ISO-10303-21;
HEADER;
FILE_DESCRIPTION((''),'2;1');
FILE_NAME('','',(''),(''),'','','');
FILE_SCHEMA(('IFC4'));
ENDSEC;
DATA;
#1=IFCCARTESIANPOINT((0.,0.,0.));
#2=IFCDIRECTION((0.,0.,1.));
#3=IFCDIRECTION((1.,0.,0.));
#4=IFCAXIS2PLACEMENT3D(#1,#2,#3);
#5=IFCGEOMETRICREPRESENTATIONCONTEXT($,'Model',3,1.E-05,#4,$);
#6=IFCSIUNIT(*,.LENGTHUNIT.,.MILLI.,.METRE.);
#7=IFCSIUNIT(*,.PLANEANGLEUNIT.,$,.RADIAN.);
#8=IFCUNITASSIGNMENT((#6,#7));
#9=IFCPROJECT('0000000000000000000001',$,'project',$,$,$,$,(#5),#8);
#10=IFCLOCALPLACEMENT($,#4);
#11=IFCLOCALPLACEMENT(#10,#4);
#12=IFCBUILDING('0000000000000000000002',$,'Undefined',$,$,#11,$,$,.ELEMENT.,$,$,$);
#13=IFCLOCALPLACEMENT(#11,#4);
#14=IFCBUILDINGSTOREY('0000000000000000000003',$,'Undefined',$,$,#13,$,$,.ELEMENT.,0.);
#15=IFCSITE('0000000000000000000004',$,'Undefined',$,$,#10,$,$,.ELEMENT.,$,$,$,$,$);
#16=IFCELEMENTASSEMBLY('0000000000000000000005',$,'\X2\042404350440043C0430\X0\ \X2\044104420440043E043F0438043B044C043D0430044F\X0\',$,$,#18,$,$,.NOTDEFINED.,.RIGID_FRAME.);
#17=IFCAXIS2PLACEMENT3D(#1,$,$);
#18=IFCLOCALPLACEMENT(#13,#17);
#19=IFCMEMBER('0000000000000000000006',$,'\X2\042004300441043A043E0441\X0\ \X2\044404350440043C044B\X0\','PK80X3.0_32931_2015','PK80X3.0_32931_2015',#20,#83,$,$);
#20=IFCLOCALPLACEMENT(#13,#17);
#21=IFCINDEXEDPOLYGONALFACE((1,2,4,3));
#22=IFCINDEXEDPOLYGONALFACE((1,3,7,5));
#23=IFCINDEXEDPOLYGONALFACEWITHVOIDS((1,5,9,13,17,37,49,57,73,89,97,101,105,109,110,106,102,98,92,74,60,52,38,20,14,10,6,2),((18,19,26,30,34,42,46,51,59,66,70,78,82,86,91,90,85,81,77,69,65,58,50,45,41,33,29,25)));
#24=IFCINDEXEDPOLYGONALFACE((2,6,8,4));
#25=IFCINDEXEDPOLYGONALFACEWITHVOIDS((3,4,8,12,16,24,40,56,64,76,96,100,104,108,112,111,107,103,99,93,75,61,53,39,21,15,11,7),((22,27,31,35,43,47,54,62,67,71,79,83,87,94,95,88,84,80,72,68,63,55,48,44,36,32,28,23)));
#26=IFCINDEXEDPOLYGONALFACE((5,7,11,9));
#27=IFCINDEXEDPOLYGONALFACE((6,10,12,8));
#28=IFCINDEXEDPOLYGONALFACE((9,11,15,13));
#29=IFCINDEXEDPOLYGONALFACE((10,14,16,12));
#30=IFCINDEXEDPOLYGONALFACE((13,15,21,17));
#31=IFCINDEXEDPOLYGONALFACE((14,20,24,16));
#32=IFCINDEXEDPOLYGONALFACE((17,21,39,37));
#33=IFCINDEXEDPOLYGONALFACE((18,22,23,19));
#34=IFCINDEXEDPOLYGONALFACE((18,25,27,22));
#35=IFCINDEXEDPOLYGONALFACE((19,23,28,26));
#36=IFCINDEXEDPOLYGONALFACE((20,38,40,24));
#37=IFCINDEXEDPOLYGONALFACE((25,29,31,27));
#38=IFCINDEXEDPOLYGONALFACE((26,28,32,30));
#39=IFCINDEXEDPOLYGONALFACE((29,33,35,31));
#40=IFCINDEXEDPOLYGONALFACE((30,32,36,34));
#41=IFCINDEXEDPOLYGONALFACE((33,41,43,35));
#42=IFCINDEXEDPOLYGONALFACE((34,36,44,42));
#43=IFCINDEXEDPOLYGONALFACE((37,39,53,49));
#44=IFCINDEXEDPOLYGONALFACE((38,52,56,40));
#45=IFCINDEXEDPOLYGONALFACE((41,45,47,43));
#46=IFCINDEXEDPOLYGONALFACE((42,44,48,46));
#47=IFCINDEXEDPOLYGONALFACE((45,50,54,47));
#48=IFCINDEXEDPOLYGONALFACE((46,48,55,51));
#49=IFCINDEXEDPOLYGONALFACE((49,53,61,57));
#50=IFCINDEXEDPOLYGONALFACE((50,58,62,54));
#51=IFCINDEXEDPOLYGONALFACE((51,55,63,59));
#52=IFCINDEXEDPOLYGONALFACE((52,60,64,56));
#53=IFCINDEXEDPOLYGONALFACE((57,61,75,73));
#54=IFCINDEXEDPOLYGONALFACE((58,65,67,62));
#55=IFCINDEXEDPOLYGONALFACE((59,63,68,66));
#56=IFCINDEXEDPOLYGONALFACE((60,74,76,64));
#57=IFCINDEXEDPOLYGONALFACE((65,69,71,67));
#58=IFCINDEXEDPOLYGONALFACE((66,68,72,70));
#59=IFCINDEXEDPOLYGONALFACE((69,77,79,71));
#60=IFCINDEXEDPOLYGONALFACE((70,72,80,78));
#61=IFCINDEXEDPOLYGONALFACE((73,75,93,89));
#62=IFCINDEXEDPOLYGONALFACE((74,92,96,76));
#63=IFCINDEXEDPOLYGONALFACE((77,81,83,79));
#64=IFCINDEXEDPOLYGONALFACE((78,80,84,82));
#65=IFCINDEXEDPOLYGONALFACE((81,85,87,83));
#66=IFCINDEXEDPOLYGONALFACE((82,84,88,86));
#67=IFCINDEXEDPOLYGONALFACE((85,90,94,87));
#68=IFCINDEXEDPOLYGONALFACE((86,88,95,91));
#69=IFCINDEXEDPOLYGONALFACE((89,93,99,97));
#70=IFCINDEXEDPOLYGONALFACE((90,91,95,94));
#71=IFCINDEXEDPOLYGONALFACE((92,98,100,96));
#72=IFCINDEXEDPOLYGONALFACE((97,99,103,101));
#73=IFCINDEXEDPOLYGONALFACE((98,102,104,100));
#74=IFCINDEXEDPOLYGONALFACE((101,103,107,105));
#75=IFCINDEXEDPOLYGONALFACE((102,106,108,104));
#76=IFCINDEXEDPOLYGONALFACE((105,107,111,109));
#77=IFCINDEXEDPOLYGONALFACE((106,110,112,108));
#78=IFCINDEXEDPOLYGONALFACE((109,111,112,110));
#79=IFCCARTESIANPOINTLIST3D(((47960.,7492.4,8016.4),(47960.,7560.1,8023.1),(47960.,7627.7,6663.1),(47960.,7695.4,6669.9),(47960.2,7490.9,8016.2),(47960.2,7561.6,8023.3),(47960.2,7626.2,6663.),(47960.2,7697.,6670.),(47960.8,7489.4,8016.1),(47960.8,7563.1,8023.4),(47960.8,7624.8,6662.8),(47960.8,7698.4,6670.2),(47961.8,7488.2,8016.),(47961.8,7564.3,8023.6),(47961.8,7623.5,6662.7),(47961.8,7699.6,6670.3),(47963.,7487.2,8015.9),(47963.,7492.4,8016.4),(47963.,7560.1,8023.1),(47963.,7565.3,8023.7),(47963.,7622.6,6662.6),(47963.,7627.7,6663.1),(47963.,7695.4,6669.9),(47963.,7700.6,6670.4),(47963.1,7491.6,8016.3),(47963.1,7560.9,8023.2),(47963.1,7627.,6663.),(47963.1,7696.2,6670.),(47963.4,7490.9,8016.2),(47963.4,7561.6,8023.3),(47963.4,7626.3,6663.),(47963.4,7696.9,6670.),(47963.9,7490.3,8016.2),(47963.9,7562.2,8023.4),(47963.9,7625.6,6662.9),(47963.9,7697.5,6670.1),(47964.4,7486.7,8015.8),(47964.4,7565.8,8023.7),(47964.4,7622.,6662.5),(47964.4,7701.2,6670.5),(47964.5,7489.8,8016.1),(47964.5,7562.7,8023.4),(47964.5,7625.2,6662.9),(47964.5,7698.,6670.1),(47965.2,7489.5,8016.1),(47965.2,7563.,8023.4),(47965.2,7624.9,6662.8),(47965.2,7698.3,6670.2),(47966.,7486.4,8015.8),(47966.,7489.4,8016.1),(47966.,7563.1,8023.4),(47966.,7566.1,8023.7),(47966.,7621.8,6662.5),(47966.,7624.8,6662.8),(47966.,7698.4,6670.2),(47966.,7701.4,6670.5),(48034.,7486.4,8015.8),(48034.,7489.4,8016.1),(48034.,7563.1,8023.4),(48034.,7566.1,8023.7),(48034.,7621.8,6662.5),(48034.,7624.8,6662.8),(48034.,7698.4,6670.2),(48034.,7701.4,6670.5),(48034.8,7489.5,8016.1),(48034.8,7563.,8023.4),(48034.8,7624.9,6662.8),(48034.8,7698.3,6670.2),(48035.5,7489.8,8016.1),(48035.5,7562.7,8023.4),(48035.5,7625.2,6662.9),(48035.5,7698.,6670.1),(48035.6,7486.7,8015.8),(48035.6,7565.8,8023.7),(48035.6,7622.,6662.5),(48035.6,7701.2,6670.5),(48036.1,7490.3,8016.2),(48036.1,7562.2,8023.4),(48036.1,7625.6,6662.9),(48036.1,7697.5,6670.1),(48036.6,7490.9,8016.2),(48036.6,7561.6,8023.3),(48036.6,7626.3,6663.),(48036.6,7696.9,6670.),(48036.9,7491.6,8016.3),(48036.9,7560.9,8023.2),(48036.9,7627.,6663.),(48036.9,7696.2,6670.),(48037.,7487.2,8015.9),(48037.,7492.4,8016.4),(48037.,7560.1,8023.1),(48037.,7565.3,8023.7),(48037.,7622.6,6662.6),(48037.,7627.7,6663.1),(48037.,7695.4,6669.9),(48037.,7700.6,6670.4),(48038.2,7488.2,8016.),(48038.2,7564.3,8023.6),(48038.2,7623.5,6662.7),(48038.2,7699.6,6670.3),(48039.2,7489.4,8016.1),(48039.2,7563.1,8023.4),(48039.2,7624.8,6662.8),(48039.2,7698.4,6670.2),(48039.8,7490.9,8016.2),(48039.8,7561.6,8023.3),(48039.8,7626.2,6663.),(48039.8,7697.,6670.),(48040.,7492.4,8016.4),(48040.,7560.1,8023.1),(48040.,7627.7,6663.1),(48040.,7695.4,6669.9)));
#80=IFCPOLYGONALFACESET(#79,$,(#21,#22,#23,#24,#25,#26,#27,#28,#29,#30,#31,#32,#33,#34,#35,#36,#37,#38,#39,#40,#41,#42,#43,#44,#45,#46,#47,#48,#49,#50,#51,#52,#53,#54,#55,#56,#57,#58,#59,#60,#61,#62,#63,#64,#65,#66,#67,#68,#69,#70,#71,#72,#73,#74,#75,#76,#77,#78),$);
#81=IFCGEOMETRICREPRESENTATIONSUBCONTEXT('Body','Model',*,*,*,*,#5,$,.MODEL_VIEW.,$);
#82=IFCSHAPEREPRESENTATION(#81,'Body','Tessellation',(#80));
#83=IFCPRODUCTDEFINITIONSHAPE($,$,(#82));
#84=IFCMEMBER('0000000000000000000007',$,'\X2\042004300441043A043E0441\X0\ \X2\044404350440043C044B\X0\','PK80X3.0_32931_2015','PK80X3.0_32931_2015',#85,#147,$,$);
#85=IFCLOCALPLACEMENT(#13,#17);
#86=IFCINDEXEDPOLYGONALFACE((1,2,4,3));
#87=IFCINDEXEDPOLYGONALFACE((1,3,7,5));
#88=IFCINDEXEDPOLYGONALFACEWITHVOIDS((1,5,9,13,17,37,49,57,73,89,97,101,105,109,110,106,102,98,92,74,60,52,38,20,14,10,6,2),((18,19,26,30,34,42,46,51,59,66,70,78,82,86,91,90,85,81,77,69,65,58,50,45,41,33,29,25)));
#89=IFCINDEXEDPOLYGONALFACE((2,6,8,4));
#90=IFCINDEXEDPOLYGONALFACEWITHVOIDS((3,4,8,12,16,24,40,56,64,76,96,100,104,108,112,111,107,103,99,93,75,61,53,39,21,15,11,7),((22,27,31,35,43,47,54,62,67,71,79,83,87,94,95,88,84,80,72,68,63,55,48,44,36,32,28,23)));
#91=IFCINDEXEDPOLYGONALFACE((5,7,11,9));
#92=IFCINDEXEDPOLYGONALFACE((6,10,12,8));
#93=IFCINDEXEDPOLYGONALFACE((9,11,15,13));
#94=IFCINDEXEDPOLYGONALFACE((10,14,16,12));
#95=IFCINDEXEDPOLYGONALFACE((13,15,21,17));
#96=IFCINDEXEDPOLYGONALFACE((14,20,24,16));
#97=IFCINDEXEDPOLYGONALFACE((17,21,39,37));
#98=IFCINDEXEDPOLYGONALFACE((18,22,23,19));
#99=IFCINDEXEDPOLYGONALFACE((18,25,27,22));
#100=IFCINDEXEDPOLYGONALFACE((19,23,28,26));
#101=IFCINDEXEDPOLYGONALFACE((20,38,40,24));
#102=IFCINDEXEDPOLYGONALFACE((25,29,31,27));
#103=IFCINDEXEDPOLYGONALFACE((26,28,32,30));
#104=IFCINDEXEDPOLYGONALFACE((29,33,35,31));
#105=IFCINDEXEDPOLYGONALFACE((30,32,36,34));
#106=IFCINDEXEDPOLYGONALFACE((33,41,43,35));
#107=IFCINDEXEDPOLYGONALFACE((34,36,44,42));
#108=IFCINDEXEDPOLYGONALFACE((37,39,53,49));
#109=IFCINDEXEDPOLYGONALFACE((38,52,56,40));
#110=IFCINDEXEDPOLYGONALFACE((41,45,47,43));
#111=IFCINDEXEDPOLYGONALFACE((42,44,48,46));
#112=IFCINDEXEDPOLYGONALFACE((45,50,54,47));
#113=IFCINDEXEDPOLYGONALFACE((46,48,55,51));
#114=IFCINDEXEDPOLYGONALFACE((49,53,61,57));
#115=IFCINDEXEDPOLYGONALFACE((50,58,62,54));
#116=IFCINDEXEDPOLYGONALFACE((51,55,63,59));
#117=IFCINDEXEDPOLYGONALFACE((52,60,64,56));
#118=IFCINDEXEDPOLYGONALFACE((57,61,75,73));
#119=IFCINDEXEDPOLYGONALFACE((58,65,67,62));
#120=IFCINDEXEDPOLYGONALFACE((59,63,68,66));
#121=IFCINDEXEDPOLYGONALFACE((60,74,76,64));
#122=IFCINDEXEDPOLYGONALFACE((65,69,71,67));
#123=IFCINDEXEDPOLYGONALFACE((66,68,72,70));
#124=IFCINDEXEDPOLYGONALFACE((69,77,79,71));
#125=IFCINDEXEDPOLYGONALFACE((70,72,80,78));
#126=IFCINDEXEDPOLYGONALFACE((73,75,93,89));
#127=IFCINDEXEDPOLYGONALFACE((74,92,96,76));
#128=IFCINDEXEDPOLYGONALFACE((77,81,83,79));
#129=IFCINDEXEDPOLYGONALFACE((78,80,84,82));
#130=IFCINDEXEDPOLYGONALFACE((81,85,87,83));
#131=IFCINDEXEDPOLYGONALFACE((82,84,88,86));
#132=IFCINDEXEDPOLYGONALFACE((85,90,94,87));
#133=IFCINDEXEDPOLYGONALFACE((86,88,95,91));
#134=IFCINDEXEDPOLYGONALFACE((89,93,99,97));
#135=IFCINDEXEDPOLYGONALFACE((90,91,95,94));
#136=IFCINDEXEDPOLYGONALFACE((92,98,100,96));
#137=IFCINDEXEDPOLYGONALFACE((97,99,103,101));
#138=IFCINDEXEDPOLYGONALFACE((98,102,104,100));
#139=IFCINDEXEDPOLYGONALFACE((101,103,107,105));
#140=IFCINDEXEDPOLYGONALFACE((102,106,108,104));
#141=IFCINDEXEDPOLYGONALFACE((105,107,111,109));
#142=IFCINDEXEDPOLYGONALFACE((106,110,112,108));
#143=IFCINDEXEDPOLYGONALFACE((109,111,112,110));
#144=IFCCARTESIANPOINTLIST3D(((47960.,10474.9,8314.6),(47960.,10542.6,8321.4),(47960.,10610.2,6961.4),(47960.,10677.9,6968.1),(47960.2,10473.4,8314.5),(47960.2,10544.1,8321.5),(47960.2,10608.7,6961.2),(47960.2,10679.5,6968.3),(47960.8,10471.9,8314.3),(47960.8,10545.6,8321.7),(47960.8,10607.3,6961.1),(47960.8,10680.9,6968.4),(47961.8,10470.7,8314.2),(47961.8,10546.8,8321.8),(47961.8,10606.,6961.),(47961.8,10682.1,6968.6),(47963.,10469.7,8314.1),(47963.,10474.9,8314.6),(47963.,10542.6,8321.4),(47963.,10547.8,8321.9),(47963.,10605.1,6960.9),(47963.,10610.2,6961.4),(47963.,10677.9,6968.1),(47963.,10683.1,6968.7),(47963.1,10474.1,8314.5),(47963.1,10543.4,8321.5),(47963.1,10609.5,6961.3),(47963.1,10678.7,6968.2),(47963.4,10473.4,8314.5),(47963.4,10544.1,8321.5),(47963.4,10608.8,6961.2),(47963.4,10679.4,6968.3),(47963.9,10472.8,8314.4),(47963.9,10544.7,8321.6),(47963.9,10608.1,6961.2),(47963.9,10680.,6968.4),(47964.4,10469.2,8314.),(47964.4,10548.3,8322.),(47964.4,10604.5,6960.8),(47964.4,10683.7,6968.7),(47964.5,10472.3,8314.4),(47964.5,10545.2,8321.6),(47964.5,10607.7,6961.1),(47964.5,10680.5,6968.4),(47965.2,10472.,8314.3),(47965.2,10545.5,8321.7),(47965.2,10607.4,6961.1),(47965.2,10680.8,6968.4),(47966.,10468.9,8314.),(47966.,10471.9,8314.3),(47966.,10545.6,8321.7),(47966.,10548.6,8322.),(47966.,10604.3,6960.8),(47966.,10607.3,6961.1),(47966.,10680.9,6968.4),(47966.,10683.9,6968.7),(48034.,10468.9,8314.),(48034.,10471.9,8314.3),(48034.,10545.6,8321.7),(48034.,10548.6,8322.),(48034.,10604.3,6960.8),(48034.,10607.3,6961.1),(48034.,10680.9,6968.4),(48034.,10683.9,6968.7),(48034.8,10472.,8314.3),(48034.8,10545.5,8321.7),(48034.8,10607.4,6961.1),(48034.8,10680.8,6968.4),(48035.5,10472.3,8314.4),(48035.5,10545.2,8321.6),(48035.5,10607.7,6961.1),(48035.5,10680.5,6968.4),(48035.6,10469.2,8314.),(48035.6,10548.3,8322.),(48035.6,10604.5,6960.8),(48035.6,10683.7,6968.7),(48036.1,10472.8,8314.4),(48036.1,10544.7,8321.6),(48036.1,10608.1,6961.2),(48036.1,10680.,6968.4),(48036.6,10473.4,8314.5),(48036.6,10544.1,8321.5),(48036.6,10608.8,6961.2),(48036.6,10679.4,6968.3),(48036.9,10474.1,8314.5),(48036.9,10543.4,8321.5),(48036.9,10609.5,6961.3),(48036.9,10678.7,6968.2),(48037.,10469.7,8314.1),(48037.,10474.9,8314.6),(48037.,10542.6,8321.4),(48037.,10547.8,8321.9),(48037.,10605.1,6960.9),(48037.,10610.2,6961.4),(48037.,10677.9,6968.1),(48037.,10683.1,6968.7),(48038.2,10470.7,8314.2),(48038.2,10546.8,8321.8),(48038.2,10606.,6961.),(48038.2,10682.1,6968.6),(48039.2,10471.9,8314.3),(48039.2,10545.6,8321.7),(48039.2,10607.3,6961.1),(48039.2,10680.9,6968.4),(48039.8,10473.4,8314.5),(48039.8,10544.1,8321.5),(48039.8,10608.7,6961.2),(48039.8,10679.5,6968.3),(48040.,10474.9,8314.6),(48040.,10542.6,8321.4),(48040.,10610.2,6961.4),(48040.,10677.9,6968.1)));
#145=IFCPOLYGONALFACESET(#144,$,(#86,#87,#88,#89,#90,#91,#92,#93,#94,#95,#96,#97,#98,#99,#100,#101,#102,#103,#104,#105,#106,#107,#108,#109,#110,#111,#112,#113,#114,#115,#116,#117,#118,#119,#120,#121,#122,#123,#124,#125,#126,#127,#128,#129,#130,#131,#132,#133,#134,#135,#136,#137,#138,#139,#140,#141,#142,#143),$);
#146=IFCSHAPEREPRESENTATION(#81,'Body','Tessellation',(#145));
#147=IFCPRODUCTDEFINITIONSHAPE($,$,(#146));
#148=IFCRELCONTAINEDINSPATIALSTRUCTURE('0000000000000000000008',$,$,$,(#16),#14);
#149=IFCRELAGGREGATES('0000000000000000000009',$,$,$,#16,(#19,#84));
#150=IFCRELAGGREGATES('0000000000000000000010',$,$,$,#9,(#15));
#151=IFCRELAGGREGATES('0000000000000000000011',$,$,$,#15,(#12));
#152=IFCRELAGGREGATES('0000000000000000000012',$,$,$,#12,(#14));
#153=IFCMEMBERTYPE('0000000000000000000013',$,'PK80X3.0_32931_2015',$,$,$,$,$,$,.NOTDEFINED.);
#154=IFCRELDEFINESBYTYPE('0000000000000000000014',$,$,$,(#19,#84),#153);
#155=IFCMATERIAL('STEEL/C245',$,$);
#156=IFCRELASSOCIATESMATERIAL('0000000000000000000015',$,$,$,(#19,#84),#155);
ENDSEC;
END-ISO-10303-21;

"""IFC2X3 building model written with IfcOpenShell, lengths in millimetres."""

from ifc_helpers import new_model, si_unit, frame, origin_with_axes, origin_2d_with_axis, place, context, subcontext, project, spatial, hollow_rectangle, extrude, material, type_object, element, aggregate, save


model = new_model("IFC2X3")

# Units and contexts
model_context = context("Model", 3, precision=1e-05, world=origin_with_axes())
body_context = subcontext(model_context, "Body", "Model", "MODEL_VIEW")
ifc_project = project(units=[si_unit("LENGTHUNIT", "METRE", prefix="MILLI"), si_unit("PLANEANGLEUNIT", "RADIAN")], contexts=[model_context])

# Site, building, storey
site_placement = place(None, origin_with_axes())
site = spatial("IfcSite", under=ifc_project, at=site_placement, Name="Undefined", CompositionType="ELEMENT")
building_placement = place(site_placement, origin_with_axes())
building = spatial("IfcBuilding", under=site, at=building_placement, Name="Undefined", CompositionType="ELEMENT")
storey_placement = place(building_placement, origin_with_axes())
storey = spatial("IfcBuildingStorey", under=building, at=storey_placement, Name="Undefined", CompositionType="ELEMENT", Elevation=0.0)

# Shared definitions
ifc_material_1 = material(Name="STEEL/C245")

# Element assembly, members
assembly_1_placement = place(storey_placement, origin_with_axes())
assembly_1 = element("IfcElementAssembly", 1, at=assembly_1_placement, inside=storey, Name="Ферма стропильная", AssemblyPlace="NOTDEFINED", PredefinedType="RIGID_FRAME")
member_type_1 = type_object("IfcMemberType", Name="PK80X3.0_32931_2015", PredefinedType="NOTDEFINED")
member_1_placement = place(assembly_1_placement, frame((48000.0, 7526.3, 8019.8), z_axis=(0.0, 0.995037, 0.099504), x_axis=(0.0, 0.099504, -0.995037)))
member_1 = element("IfcMember", 2, at=member_1_placement, type_object=member_type_1, material=ifc_material_1, Name="Раскос фермы", Description="PK80X3.0_32931_2015", ObjectType="PK80X3.0_32931_2015", context=body_context, shape_type="SweptSolid", body=[
    extrude(hollow_rectangle(XDim=80.0, YDim=80.0, WallThickness=3.0, InnerFilletRadius=3.0, OuterFilletRadius=6.0, at=origin_2d_with_axis()), frame((1360.0, 0.0, 0.0), z_axis=(-1.0, 0.0, 0.0), x_axis=(0.0, -1.0, 0.0)), (0.0, 0.0, 1.0), 1360.0),
])
member_2_placement = place(assembly_1_placement, frame((48000.0, 10508.8, 8318.0), z_axis=(0.0, 0.995037, 0.099504), x_axis=(0.0, 0.099504, -0.995037)))
member_2 = element("IfcMember", 3, at=member_2_placement, type_object=member_type_1, material=ifc_material_1, Name="Раскос фермы", Description="PK80X3.0_32931_2015", ObjectType="PK80X3.0_32931_2015", context=body_context, shape_type="SweptSolid", body=[
    extrude(hollow_rectangle(XDim=80.0, YDim=80.0, WallThickness=3.0, InnerFilletRadius=3.0, OuterFilletRadius=6.0, at=origin_2d_with_axis()), frame((1360.0, 0.0, 0.0), z_axis=(-1.0, 0.0, 0.0), x_axis=(0.0, -1.0, 0.0)), (0.0, 0.0, 1.0), 1360.0),
])
aggregate(assembly_1, [member_1, member_2])

save(model, "model.ifc")
